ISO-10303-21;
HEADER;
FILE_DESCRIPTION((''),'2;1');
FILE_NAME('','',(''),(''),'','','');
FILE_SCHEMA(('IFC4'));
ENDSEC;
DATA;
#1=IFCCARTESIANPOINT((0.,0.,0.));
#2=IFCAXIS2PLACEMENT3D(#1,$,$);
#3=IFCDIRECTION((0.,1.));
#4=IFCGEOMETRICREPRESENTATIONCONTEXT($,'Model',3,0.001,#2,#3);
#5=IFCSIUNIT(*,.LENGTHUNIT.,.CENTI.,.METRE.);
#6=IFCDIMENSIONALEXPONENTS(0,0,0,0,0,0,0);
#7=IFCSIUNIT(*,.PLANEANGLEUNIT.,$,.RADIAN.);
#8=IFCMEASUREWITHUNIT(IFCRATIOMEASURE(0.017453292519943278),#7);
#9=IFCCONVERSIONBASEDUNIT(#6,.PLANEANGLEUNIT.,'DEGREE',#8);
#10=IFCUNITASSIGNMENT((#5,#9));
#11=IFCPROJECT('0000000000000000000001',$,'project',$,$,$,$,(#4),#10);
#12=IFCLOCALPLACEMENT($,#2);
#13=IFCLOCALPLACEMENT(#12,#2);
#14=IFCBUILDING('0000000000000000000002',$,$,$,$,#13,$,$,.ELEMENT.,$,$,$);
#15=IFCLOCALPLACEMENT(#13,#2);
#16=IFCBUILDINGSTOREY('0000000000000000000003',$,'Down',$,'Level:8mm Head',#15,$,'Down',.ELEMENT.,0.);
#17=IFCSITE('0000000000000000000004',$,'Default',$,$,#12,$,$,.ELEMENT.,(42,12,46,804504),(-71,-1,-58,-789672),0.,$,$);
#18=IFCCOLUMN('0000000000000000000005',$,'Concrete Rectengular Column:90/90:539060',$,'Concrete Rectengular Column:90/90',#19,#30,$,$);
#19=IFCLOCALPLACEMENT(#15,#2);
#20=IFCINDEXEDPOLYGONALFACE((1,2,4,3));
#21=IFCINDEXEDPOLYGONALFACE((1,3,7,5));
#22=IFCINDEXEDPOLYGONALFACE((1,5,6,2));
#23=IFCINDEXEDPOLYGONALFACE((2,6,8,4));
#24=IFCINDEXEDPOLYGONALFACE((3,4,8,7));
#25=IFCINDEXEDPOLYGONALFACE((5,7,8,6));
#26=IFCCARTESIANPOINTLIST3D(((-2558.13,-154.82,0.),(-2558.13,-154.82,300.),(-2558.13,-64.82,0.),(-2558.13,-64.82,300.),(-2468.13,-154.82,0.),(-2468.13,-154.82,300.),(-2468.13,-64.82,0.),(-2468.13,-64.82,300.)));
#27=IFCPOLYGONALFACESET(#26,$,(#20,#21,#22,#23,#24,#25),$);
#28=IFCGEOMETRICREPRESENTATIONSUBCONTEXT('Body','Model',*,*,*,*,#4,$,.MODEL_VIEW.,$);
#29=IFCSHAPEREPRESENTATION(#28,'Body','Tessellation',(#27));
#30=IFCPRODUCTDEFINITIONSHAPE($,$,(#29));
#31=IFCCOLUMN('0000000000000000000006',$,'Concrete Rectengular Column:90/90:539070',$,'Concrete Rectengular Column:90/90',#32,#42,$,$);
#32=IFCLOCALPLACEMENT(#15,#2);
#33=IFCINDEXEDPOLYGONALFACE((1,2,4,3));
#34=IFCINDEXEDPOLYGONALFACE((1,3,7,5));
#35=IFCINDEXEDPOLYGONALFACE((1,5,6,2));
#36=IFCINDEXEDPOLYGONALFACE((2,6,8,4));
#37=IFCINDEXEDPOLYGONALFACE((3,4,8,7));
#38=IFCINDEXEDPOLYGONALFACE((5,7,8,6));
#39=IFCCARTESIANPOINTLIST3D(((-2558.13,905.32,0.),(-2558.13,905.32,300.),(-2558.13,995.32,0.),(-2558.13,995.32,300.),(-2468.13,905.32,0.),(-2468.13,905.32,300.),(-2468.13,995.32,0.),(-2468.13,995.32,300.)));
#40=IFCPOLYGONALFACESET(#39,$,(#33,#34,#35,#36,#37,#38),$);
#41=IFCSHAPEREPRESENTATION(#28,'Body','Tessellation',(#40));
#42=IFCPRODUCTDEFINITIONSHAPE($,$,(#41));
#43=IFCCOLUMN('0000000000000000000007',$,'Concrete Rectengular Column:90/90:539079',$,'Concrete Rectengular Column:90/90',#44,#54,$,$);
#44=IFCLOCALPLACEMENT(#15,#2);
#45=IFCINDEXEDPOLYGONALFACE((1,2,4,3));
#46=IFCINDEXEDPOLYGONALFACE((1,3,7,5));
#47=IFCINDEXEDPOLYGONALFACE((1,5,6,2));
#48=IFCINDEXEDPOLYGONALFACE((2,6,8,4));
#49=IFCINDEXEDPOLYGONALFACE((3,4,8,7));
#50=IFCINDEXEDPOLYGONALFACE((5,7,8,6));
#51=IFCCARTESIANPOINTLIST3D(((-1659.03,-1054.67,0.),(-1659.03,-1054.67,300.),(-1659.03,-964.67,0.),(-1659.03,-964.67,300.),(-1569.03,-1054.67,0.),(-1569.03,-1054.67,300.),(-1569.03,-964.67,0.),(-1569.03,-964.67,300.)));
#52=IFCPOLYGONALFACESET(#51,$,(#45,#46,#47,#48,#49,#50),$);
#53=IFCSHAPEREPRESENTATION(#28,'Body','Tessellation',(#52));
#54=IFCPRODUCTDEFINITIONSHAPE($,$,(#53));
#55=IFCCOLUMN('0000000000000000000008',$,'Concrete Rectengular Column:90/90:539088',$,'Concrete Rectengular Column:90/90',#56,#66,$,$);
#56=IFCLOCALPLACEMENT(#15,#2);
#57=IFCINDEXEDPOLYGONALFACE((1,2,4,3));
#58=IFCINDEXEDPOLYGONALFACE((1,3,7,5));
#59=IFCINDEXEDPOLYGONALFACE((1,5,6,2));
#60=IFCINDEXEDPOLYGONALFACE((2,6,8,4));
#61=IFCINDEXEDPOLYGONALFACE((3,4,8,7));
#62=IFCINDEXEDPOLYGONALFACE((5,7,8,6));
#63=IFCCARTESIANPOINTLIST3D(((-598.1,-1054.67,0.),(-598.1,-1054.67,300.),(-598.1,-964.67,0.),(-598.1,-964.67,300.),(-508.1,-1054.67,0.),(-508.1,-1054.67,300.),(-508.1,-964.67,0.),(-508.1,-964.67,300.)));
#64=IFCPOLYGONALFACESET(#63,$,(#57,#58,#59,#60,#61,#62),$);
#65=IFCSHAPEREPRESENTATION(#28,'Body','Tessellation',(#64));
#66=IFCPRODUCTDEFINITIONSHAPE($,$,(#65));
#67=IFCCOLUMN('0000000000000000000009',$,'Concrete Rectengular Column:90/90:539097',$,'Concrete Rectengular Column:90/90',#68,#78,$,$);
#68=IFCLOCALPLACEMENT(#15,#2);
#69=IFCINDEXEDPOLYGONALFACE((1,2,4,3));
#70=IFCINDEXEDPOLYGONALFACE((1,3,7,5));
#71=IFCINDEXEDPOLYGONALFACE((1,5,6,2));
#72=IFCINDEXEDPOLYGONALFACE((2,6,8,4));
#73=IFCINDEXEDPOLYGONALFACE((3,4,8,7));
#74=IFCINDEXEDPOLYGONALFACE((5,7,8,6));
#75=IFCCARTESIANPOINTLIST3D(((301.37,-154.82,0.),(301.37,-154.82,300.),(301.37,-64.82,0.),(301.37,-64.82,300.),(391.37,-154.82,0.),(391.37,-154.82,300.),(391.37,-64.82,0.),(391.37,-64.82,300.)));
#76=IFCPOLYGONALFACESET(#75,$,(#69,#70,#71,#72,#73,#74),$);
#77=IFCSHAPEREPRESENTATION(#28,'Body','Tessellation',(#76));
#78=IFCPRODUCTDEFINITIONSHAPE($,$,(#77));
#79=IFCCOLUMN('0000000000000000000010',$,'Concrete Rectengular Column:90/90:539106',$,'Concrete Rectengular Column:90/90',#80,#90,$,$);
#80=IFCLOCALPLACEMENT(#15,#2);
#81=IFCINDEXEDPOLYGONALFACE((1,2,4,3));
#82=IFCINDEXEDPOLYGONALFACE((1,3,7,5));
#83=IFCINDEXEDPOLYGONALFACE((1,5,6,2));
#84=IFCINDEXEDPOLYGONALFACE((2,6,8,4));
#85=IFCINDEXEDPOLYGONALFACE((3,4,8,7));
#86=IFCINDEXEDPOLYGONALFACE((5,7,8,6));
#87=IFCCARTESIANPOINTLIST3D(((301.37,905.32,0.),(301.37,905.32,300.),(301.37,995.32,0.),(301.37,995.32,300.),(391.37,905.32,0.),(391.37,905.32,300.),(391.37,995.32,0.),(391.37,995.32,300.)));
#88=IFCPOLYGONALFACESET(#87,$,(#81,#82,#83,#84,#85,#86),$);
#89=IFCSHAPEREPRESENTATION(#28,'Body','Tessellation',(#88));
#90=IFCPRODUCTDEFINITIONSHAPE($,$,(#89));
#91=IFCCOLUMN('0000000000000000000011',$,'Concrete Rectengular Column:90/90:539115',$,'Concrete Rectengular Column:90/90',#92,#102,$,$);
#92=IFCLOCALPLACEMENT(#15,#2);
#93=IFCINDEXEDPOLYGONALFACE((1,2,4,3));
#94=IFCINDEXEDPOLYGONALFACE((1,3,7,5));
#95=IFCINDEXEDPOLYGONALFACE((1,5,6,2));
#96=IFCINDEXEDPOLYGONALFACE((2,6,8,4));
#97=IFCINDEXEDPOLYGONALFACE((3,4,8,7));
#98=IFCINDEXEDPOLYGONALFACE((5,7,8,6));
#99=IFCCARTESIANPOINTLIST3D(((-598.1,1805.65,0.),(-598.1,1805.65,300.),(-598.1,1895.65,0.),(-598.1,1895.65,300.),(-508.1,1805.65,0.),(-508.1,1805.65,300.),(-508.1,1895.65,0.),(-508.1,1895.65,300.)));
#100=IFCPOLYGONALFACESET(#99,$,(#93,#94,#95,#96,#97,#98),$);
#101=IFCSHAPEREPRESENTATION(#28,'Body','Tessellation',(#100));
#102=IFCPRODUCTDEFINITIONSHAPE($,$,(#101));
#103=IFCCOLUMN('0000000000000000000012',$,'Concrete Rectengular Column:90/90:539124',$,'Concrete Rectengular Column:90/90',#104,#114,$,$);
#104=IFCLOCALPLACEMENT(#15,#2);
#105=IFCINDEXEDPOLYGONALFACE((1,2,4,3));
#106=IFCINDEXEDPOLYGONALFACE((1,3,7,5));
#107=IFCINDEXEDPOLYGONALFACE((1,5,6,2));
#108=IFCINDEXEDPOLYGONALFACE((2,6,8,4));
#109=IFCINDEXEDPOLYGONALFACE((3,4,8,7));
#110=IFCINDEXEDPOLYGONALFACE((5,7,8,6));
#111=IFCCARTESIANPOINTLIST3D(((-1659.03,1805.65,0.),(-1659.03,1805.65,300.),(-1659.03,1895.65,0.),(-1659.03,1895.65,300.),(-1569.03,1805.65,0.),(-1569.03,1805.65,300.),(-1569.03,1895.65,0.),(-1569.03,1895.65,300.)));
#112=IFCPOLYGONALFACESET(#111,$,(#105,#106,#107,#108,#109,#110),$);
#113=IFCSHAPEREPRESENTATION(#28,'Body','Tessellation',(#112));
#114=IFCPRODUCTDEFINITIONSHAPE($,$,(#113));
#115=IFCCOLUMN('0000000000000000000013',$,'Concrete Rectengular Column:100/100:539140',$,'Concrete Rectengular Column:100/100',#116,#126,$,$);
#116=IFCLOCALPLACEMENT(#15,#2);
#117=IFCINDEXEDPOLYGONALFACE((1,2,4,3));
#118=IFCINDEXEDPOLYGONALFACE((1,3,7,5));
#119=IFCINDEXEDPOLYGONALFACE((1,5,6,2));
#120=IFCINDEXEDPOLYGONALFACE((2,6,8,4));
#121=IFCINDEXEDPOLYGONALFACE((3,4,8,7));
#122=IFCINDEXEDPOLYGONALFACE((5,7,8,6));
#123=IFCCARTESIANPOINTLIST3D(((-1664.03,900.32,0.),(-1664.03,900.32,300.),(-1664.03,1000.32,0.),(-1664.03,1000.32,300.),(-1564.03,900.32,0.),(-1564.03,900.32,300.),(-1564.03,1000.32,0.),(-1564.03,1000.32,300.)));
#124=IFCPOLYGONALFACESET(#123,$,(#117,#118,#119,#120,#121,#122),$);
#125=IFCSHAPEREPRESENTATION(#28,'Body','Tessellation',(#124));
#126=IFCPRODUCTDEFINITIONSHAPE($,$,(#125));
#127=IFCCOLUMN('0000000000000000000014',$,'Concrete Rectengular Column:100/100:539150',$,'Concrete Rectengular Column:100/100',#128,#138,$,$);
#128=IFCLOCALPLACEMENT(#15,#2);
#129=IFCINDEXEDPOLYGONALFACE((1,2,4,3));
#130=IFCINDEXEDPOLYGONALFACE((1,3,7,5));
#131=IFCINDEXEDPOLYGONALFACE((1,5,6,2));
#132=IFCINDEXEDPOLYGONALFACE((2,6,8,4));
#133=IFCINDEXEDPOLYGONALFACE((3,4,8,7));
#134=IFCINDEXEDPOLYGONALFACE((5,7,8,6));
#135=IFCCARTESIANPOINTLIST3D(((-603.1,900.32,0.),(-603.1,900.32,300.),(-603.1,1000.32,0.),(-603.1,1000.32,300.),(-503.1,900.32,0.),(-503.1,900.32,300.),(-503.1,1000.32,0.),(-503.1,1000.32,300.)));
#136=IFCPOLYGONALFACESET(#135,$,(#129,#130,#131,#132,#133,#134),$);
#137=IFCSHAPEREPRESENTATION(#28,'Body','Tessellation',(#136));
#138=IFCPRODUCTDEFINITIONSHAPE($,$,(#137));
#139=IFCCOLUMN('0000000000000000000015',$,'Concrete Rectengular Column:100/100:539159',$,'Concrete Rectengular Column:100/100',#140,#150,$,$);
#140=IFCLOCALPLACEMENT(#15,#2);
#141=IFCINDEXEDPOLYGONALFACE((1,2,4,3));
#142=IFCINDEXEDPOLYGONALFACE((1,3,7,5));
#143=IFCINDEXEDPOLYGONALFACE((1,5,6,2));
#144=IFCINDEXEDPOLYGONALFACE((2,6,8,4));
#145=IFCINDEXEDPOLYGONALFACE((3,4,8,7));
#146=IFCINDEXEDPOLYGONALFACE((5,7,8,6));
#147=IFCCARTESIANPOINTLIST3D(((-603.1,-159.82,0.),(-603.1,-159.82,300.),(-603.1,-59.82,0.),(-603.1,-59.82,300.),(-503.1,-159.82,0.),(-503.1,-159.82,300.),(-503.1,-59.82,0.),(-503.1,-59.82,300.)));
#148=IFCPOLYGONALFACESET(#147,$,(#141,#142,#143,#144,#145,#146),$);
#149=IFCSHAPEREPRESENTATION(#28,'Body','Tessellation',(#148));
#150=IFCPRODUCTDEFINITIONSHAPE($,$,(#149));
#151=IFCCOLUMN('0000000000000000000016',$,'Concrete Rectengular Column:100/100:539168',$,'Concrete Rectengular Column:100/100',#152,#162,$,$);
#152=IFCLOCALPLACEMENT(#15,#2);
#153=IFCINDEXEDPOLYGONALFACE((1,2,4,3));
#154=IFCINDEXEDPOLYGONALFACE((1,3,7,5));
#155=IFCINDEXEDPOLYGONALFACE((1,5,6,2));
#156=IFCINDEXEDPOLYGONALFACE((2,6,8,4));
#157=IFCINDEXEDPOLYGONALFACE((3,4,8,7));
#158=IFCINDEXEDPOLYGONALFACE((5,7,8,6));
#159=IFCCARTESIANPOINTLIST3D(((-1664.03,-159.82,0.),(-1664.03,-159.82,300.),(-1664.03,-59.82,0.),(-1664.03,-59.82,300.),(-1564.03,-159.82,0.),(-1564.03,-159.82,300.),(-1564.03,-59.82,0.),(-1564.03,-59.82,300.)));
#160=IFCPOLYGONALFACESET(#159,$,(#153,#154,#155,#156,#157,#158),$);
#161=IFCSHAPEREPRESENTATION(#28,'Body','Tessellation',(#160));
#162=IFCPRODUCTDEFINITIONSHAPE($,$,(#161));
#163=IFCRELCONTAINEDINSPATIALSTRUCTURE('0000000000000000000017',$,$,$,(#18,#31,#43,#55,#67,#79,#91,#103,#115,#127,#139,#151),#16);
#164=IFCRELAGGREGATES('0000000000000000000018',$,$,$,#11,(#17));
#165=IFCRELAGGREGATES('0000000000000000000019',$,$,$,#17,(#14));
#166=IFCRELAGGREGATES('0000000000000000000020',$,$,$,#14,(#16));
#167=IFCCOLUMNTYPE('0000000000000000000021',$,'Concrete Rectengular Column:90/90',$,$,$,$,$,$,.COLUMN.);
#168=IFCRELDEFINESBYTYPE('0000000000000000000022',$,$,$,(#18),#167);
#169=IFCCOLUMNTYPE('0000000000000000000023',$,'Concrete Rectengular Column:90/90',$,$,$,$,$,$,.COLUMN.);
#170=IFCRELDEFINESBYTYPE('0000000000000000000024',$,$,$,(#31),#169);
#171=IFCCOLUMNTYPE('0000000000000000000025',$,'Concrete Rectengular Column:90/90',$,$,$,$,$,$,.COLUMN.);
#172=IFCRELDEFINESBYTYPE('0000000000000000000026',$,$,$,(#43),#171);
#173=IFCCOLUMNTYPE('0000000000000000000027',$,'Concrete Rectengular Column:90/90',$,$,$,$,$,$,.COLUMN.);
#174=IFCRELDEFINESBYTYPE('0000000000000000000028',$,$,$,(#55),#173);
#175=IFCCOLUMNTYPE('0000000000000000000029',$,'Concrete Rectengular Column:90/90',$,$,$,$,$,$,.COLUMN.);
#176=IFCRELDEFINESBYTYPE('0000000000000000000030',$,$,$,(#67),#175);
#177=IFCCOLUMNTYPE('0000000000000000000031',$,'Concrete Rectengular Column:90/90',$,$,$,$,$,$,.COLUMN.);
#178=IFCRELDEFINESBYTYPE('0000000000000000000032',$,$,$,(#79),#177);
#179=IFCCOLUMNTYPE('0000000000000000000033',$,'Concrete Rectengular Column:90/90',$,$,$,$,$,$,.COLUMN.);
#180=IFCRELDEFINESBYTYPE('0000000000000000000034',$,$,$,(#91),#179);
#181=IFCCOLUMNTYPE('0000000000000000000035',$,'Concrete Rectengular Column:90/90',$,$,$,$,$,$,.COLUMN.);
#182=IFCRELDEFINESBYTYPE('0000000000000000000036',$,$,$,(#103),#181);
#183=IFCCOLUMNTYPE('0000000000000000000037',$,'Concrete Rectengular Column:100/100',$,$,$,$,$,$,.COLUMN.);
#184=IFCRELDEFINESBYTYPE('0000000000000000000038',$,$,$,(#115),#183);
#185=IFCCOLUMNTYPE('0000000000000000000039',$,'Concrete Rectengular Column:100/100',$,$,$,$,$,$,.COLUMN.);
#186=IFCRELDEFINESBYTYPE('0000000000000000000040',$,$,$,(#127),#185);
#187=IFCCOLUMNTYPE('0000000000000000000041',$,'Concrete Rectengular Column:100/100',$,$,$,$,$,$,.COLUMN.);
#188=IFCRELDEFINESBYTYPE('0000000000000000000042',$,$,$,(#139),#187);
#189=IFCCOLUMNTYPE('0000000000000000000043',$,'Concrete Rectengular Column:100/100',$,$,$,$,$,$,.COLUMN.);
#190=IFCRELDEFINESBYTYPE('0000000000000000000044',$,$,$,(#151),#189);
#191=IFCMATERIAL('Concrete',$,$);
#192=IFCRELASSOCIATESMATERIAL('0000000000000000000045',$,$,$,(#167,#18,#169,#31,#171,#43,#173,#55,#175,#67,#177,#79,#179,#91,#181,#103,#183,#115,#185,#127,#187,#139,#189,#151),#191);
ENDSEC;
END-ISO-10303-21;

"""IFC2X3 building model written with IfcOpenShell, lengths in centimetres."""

from ifc_helpers import new_model, entity, si_unit, converted_unit, direction, frame, frame_2d, origin, origin_2d_with_axis, place, context, subcontext, project, spatial, rectangle, extrude, source, transform, mapped, material, type_object, type_shapes, element, save


model = new_model("IFC2X3")

# Units and contexts
model_context = context("Model", 3, precision=0.001, world=origin(), true_north=direction((0.0, 1.0)))
body_context = subcontext(model_context, "Body", "Model", "MODEL_VIEW")
ifc_project = project(units=[si_unit("LENGTHUNIT", "METRE", prefix="CENTI"), converted_unit("PLANEANGLEUNIT", "DEGREE", entity("IfcRatioMeasure", 0.017453292519943278), si_unit("PLANEANGLEUNIT", "RADIAN"), dimensions=[0, 0, 0, 0, 0, 0, 0])], contexts=[model_context])

# Site, building, storey
site_placement = place(None, origin())
site = spatial("IfcSite", under=ifc_project, at=site_placement, Name="Default", CompositionType="ELEMENT", RefLatitude=(42, 12, 46, 804504), RefLongitude=(-71, -1, -58, -789672), RefElevation=0.0)
building_placement = place(site_placement, origin())
building = spatial("IfcBuilding", under=site, at=building_placement, CompositionType="ELEMENT")
storey_placement = place(building_placement, origin())
storey = spatial("IfcBuildingStorey", under=building, at=storey_placement, Name="Down", ObjectType="Level:8mm Head", LongName="Down", CompositionType="ELEMENT", Elevation=0.0)

# Columns
ifc_material = material(Name="Concrete")
column_type_1 = type_object("IfcColumnType", Name="Concrete Rectengular Column:90/90", PredefinedType="COLUMN", material=ifc_material)
shared_shape_1 = source(origin(), body_context, "Body", "SweptSolid", [
    extrude(rectangle(XDim=90.0, YDim=90.0, at=frame_2d((0.0, 0.0), x_axis=(1.0, 0.0))), frame((-2513.13, -109.82, 0.0), z_axis=(0.0, 0.0, 1.0), x_axis=(0.0, -1.0, 0.0)), (0.0, 0.0, 1.0), 300.0),
])
type_shapes(column_type_1, [shared_shape_1])
column_1_placement = place(storey_placement, origin())
element("IfcColumn", 1, at=column_1_placement, inside=storey, type_object=column_type_1, material=ifc_material, Name="Concrete Rectengular Column:90/90:539060", ObjectType="Concrete Rectengular Column:90/90", context=body_context, shape_type="MappedRepresentation", body=[
    mapped(shared_shape_1, transform((0.0, 0.0, 0.0), scale=1.0)),
])
column_type_2 = type_object("IfcColumnType", Name="Concrete Rectengular Column:90/90", PredefinedType="COLUMN", material=ifc_material)
shared_shape_2 = source(origin(), body_context, "Body", "SweptSolid", [
    extrude(rectangle(XDim=90.0, YDim=90.0, at=frame_2d((0.0, 0.0), x_axis=(1.0, 0.0))), frame((-2513.13, 950.32, 0.0), z_axis=(0.0, 0.0, 1.0), x_axis=(0.0, -1.0, 0.0)), (0.0, 0.0, 1.0), 300.0),
])
type_shapes(column_type_2, [shared_shape_2])
column_2_placement = place(storey_placement, origin())
element("IfcColumn", 2, at=column_2_placement, inside=storey, type_object=column_type_2, material=ifc_material, Name="Concrete Rectengular Column:90/90:539070", ObjectType="Concrete Rectengular Column:90/90", context=body_context, shape_type="MappedRepresentation", body=[
    mapped(shared_shape_2, transform((0.0, 0.0, 0.0), scale=1.0)),
])
column_type_3 = type_object("IfcColumnType", Name="Concrete Rectengular Column:90/90", PredefinedType="COLUMN", material=ifc_material)
shared_shape_3 = source(origin(), body_context, "Body", "SweptSolid", [
    extrude(rectangle(XDim=90.0, YDim=90.0, at=origin_2d_with_axis()), frame((-1614.03, -1009.67, 0.0), z_axis=(0.0, 0.0, 1.0), x_axis=(0.0, -1.0, 0.0)), (0.0, 0.0, 1.0), 300.0),
])
type_shapes(column_type_3, [shared_shape_3])
column_3_placement = place(storey_placement, origin())
element("IfcColumn", 3, at=column_3_placement, inside=storey, type_object=column_type_3, material=ifc_material, Name="Concrete Rectengular Column:90/90:539079", ObjectType="Concrete Rectengular Column:90/90", context=body_context, shape_type="MappedRepresentation", body=[
    mapped(shared_shape_3, transform((0.0, 0.0, 0.0), scale=1.0)),
])
column_type_4 = type_object("IfcColumnType", Name="Concrete Rectengular Column:90/90", PredefinedType="COLUMN", material=ifc_material)
shared_shape_4 = source(origin(), body_context, "Body", "SweptSolid", [
    extrude(rectangle(XDim=90.0, YDim=90.0, at=frame_2d((0.0, 0.0), x_axis=(1.0, 0.0))), frame((-553.1, -1009.67, 0.0), z_axis=(0.0, 0.0, 1.0), x_axis=(0.0, -1.0, 0.0)), (0.0, 0.0, 1.0), 300.0),
])
type_shapes(column_type_4, [shared_shape_4])
column_4_placement = place(storey_placement, origin())
element("IfcColumn", 4, at=column_4_placement, inside=storey, type_object=column_type_4, material=ifc_material, Name="Concrete Rectengular Column:90/90:539088", ObjectType="Concrete Rectengular Column:90/90", context=body_context, shape_type="MappedRepresentation", body=[
    mapped(shared_shape_4, transform((0.0, 0.0, 0.0), scale=1.0)),
])
column_type_5 = type_object("IfcColumnType", Name="Concrete Rectengular Column:90/90", PredefinedType="COLUMN", material=ifc_material)
shared_shape_5 = source(origin(), body_context, "Body", "SweptSolid", [
    extrude(rectangle(XDim=90.0, YDim=90.0, at=frame_2d((0.0, 0.0), x_axis=(1.0, 0.0))), frame((346.37, -109.82, 0.0), z_axis=(0.0, 0.0, 1.0), x_axis=(0.0, -1.0, 0.0)), (0.0, 0.0, 1.0), 300.0),
])
type_shapes(column_type_5, [shared_shape_5])
column_5_placement = place(storey_placement, origin())
element("IfcColumn", 5, at=column_5_placement, inside=storey, type_object=column_type_5, material=ifc_material, Name="Concrete Rectengular Column:90/90:539097", ObjectType="Concrete Rectengular Column:90/90", context=body_context, shape_type="MappedRepresentation", body=[
    mapped(shared_shape_5, transform((0.0, 0.0, 0.0), scale=1.0)),
])
column_type_6 = type_object("IfcColumnType", Name="Concrete Rectengular Column:90/90", PredefinedType="COLUMN", material=ifc_material)
shared_shape_6 = source(origin(), body_context, "Body", "SweptSolid", [
    extrude(rectangle(XDim=90.0, YDim=90.0, at=frame_2d((0.0, 0.0), x_axis=(1.0, 0.0))), frame((346.37, 950.32, 0.0), z_axis=(0.0, 0.0, 1.0), x_axis=(0.0, -1.0, 0.0)), (0.0, 0.0, 1.0), 300.0),
])
type_shapes(column_type_6, [shared_shape_6])
column_6_placement = place(storey_placement, origin())
element("IfcColumn", 6, at=column_6_placement, inside=storey, type_object=column_type_6, material=ifc_material, Name="Concrete Rectengular Column:90/90:539106", ObjectType="Concrete Rectengular Column:90/90", context=body_context, shape_type="MappedRepresentation", body=[
    mapped(shared_shape_6, transform((0.0, 0.0, 0.0), scale=1.0)),
])
column_type_7 = type_object("IfcColumnType", Name="Concrete Rectengular Column:90/90", PredefinedType="COLUMN", material=ifc_material)
shared_shape_7 = source(origin(), body_context, "Body", "SweptSolid", [
    extrude(rectangle(XDim=90.0, YDim=90.0, at=frame_2d((0.0, 0.0), x_axis=(1.0, 0.0))), frame((-553.1, 1850.65, 0.0), z_axis=(0.0, 0.0, 1.0), x_axis=(0.0, -1.0, 0.0)), (0.0, 0.0, 1.0), 300.0),
])
type_shapes(column_type_7, [shared_shape_7])
column_7_placement = place(storey_placement, origin())
element("IfcColumn", 7, at=column_7_placement, inside=storey, type_object=column_type_7, material=ifc_material, Name="Concrete Rectengular Column:90/90:539115", ObjectType="Concrete Rectengular Column:90/90", context=body_context, shape_type="MappedRepresentation", body=[
    mapped(shared_shape_7, transform((0.0, 0.0, 0.0), scale=1.0)),
])
column_type_8 = type_object("IfcColumnType", Name="Concrete Rectengular Column:90/90", PredefinedType="COLUMN", material=ifc_material)
shared_shape_8 = source(origin(), body_context, "Body", "SweptSolid", [
    extrude(rectangle(XDim=90.0, YDim=90.0, at=origin_2d_with_axis()), frame((-1614.03, 1850.65, 0.0), z_axis=(0.0, 0.0, 1.0), x_axis=(0.0, -1.0, 0.0)), (0.0, 0.0, 1.0), 300.0),
])
type_shapes(column_type_8, [shared_shape_8])
column_8_placement = place(storey_placement, origin())
element("IfcColumn", 8, at=column_8_placement, inside=storey, type_object=column_type_8, material=ifc_material, Name="Concrete Rectengular Column:90/90:539124", ObjectType="Concrete Rectengular Column:90/90", context=body_context, shape_type="MappedRepresentation", body=[
    mapped(shared_shape_8, transform((0.0, 0.0, 0.0), scale=1.0)),
])
column_type_9 = type_object("IfcColumnType", Name="Concrete Rectengular Column:100/100", PredefinedType="COLUMN", material=ifc_material)
shared_shape_9 = source(origin(), body_context, "Body", "SweptSolid", [
    extrude(rectangle(XDim=100.0, YDim=100.0, at=frame_2d((0.0, 0.0), x_axis=(1.0, 0.0))), frame((-1614.03, 950.32, 0.0), z_axis=(0.0, 0.0, 1.0), x_axis=(0.0, -1.0, 0.0)), (0.0, 0.0, 1.0), 300.0),
])
type_shapes(column_type_9, [shared_shape_9])
column_9_placement = place(storey_placement, origin())
element("IfcColumn", 9, at=column_9_placement, inside=storey, type_object=column_type_9, material=ifc_material, Name="Concrete Rectengular Column:100/100:539140", ObjectType="Concrete Rectengular Column:100/100", context=body_context, shape_type="MappedRepresentation", body=[
    mapped(shared_shape_9, transform((0.0, 0.0, 0.0), scale=1.0)),
])
column_type_10 = type_object("IfcColumnType", Name="Concrete Rectengular Column:100/100", PredefinedType="COLUMN", material=ifc_material)
shared_shape_10 = source(origin(), body_context, "Body", "SweptSolid", [
    extrude(rectangle(XDim=100.0, YDim=100.0, at=origin_2d_with_axis()), frame((-553.1, 950.32, 0.0), z_axis=(0.0, 0.0, 1.0), x_axis=(0.0, -1.0, 0.0)), (0.0, 0.0, 1.0), 300.0),
])
type_shapes(column_type_10, [shared_shape_10])
column_10_placement = place(storey_placement, origin())
element("IfcColumn", 10, at=column_10_placement, inside=storey, type_object=column_type_10, material=ifc_material, Name="Concrete Rectengular Column:100/100:539150", ObjectType="Concrete Rectengular Column:100/100", context=body_context, shape_type="MappedRepresentation", body=[
    mapped(shared_shape_10, transform((0.0, 0.0, 0.0), scale=1.0)),
])
column_type_11 = type_object("IfcColumnType", Name="Concrete Rectengular Column:100/100", PredefinedType="COLUMN", material=ifc_material)
shared_shape_11 = source(origin(), body_context, "Body", "SweptSolid", [
    extrude(rectangle(XDim=100.0, YDim=100.0, at=origin_2d_with_axis()), frame((-553.1, -109.82, 0.0), z_axis=(0.0, 0.0, 1.0), x_axis=(0.0, -1.0, 0.0)), (0.0, 0.0, 1.0), 300.0),
])
type_shapes(column_type_11, [shared_shape_11])
column_11_placement = place(storey_placement, origin())
element("IfcColumn", 11, at=column_11_placement, inside=storey, type_object=column_type_11, material=ifc_material, Name="Concrete Rectengular Column:100/100:539159", ObjectType="Concrete Rectengular Column:100/100", context=body_context, shape_type="MappedRepresentation", body=[
    mapped(shared_shape_11, transform((0.0, 0.0, 0.0), scale=1.0)),
])
column_type_12 = type_object("IfcColumnType", Name="Concrete Rectengular Column:100/100", PredefinedType="COLUMN", material=ifc_material)
shared_shape_12 = source(origin(), body_context, "Body", "SweptSolid", [
    extrude(rectangle(XDim=100.0, YDim=100.0, at=frame_2d((0.0, 0.0), x_axis=(1.0, 0.0))), frame((-1614.03, -109.82, 0.0), z_axis=(0.0, 0.0, 1.0), x_axis=(0.0, -1.0, 0.0)), (0.0, 0.0, 1.0), 300.0),
])
type_shapes(column_type_12, [shared_shape_12])
column_12_placement = place(storey_placement, origin())
element("IfcColumn", 12, at=column_12_placement, inside=storey, type_object=column_type_12, material=ifc_material, Name="Concrete Rectengular Column:100/100:539168", ObjectType="Concrete Rectengular Column:100/100", context=body_context, shape_type="MappedRepresentation", body=[
    mapped(shared_shape_12, transform((0.0, 0.0, 0.0), scale=1.0)),
])

save(model, "model.ifc")
